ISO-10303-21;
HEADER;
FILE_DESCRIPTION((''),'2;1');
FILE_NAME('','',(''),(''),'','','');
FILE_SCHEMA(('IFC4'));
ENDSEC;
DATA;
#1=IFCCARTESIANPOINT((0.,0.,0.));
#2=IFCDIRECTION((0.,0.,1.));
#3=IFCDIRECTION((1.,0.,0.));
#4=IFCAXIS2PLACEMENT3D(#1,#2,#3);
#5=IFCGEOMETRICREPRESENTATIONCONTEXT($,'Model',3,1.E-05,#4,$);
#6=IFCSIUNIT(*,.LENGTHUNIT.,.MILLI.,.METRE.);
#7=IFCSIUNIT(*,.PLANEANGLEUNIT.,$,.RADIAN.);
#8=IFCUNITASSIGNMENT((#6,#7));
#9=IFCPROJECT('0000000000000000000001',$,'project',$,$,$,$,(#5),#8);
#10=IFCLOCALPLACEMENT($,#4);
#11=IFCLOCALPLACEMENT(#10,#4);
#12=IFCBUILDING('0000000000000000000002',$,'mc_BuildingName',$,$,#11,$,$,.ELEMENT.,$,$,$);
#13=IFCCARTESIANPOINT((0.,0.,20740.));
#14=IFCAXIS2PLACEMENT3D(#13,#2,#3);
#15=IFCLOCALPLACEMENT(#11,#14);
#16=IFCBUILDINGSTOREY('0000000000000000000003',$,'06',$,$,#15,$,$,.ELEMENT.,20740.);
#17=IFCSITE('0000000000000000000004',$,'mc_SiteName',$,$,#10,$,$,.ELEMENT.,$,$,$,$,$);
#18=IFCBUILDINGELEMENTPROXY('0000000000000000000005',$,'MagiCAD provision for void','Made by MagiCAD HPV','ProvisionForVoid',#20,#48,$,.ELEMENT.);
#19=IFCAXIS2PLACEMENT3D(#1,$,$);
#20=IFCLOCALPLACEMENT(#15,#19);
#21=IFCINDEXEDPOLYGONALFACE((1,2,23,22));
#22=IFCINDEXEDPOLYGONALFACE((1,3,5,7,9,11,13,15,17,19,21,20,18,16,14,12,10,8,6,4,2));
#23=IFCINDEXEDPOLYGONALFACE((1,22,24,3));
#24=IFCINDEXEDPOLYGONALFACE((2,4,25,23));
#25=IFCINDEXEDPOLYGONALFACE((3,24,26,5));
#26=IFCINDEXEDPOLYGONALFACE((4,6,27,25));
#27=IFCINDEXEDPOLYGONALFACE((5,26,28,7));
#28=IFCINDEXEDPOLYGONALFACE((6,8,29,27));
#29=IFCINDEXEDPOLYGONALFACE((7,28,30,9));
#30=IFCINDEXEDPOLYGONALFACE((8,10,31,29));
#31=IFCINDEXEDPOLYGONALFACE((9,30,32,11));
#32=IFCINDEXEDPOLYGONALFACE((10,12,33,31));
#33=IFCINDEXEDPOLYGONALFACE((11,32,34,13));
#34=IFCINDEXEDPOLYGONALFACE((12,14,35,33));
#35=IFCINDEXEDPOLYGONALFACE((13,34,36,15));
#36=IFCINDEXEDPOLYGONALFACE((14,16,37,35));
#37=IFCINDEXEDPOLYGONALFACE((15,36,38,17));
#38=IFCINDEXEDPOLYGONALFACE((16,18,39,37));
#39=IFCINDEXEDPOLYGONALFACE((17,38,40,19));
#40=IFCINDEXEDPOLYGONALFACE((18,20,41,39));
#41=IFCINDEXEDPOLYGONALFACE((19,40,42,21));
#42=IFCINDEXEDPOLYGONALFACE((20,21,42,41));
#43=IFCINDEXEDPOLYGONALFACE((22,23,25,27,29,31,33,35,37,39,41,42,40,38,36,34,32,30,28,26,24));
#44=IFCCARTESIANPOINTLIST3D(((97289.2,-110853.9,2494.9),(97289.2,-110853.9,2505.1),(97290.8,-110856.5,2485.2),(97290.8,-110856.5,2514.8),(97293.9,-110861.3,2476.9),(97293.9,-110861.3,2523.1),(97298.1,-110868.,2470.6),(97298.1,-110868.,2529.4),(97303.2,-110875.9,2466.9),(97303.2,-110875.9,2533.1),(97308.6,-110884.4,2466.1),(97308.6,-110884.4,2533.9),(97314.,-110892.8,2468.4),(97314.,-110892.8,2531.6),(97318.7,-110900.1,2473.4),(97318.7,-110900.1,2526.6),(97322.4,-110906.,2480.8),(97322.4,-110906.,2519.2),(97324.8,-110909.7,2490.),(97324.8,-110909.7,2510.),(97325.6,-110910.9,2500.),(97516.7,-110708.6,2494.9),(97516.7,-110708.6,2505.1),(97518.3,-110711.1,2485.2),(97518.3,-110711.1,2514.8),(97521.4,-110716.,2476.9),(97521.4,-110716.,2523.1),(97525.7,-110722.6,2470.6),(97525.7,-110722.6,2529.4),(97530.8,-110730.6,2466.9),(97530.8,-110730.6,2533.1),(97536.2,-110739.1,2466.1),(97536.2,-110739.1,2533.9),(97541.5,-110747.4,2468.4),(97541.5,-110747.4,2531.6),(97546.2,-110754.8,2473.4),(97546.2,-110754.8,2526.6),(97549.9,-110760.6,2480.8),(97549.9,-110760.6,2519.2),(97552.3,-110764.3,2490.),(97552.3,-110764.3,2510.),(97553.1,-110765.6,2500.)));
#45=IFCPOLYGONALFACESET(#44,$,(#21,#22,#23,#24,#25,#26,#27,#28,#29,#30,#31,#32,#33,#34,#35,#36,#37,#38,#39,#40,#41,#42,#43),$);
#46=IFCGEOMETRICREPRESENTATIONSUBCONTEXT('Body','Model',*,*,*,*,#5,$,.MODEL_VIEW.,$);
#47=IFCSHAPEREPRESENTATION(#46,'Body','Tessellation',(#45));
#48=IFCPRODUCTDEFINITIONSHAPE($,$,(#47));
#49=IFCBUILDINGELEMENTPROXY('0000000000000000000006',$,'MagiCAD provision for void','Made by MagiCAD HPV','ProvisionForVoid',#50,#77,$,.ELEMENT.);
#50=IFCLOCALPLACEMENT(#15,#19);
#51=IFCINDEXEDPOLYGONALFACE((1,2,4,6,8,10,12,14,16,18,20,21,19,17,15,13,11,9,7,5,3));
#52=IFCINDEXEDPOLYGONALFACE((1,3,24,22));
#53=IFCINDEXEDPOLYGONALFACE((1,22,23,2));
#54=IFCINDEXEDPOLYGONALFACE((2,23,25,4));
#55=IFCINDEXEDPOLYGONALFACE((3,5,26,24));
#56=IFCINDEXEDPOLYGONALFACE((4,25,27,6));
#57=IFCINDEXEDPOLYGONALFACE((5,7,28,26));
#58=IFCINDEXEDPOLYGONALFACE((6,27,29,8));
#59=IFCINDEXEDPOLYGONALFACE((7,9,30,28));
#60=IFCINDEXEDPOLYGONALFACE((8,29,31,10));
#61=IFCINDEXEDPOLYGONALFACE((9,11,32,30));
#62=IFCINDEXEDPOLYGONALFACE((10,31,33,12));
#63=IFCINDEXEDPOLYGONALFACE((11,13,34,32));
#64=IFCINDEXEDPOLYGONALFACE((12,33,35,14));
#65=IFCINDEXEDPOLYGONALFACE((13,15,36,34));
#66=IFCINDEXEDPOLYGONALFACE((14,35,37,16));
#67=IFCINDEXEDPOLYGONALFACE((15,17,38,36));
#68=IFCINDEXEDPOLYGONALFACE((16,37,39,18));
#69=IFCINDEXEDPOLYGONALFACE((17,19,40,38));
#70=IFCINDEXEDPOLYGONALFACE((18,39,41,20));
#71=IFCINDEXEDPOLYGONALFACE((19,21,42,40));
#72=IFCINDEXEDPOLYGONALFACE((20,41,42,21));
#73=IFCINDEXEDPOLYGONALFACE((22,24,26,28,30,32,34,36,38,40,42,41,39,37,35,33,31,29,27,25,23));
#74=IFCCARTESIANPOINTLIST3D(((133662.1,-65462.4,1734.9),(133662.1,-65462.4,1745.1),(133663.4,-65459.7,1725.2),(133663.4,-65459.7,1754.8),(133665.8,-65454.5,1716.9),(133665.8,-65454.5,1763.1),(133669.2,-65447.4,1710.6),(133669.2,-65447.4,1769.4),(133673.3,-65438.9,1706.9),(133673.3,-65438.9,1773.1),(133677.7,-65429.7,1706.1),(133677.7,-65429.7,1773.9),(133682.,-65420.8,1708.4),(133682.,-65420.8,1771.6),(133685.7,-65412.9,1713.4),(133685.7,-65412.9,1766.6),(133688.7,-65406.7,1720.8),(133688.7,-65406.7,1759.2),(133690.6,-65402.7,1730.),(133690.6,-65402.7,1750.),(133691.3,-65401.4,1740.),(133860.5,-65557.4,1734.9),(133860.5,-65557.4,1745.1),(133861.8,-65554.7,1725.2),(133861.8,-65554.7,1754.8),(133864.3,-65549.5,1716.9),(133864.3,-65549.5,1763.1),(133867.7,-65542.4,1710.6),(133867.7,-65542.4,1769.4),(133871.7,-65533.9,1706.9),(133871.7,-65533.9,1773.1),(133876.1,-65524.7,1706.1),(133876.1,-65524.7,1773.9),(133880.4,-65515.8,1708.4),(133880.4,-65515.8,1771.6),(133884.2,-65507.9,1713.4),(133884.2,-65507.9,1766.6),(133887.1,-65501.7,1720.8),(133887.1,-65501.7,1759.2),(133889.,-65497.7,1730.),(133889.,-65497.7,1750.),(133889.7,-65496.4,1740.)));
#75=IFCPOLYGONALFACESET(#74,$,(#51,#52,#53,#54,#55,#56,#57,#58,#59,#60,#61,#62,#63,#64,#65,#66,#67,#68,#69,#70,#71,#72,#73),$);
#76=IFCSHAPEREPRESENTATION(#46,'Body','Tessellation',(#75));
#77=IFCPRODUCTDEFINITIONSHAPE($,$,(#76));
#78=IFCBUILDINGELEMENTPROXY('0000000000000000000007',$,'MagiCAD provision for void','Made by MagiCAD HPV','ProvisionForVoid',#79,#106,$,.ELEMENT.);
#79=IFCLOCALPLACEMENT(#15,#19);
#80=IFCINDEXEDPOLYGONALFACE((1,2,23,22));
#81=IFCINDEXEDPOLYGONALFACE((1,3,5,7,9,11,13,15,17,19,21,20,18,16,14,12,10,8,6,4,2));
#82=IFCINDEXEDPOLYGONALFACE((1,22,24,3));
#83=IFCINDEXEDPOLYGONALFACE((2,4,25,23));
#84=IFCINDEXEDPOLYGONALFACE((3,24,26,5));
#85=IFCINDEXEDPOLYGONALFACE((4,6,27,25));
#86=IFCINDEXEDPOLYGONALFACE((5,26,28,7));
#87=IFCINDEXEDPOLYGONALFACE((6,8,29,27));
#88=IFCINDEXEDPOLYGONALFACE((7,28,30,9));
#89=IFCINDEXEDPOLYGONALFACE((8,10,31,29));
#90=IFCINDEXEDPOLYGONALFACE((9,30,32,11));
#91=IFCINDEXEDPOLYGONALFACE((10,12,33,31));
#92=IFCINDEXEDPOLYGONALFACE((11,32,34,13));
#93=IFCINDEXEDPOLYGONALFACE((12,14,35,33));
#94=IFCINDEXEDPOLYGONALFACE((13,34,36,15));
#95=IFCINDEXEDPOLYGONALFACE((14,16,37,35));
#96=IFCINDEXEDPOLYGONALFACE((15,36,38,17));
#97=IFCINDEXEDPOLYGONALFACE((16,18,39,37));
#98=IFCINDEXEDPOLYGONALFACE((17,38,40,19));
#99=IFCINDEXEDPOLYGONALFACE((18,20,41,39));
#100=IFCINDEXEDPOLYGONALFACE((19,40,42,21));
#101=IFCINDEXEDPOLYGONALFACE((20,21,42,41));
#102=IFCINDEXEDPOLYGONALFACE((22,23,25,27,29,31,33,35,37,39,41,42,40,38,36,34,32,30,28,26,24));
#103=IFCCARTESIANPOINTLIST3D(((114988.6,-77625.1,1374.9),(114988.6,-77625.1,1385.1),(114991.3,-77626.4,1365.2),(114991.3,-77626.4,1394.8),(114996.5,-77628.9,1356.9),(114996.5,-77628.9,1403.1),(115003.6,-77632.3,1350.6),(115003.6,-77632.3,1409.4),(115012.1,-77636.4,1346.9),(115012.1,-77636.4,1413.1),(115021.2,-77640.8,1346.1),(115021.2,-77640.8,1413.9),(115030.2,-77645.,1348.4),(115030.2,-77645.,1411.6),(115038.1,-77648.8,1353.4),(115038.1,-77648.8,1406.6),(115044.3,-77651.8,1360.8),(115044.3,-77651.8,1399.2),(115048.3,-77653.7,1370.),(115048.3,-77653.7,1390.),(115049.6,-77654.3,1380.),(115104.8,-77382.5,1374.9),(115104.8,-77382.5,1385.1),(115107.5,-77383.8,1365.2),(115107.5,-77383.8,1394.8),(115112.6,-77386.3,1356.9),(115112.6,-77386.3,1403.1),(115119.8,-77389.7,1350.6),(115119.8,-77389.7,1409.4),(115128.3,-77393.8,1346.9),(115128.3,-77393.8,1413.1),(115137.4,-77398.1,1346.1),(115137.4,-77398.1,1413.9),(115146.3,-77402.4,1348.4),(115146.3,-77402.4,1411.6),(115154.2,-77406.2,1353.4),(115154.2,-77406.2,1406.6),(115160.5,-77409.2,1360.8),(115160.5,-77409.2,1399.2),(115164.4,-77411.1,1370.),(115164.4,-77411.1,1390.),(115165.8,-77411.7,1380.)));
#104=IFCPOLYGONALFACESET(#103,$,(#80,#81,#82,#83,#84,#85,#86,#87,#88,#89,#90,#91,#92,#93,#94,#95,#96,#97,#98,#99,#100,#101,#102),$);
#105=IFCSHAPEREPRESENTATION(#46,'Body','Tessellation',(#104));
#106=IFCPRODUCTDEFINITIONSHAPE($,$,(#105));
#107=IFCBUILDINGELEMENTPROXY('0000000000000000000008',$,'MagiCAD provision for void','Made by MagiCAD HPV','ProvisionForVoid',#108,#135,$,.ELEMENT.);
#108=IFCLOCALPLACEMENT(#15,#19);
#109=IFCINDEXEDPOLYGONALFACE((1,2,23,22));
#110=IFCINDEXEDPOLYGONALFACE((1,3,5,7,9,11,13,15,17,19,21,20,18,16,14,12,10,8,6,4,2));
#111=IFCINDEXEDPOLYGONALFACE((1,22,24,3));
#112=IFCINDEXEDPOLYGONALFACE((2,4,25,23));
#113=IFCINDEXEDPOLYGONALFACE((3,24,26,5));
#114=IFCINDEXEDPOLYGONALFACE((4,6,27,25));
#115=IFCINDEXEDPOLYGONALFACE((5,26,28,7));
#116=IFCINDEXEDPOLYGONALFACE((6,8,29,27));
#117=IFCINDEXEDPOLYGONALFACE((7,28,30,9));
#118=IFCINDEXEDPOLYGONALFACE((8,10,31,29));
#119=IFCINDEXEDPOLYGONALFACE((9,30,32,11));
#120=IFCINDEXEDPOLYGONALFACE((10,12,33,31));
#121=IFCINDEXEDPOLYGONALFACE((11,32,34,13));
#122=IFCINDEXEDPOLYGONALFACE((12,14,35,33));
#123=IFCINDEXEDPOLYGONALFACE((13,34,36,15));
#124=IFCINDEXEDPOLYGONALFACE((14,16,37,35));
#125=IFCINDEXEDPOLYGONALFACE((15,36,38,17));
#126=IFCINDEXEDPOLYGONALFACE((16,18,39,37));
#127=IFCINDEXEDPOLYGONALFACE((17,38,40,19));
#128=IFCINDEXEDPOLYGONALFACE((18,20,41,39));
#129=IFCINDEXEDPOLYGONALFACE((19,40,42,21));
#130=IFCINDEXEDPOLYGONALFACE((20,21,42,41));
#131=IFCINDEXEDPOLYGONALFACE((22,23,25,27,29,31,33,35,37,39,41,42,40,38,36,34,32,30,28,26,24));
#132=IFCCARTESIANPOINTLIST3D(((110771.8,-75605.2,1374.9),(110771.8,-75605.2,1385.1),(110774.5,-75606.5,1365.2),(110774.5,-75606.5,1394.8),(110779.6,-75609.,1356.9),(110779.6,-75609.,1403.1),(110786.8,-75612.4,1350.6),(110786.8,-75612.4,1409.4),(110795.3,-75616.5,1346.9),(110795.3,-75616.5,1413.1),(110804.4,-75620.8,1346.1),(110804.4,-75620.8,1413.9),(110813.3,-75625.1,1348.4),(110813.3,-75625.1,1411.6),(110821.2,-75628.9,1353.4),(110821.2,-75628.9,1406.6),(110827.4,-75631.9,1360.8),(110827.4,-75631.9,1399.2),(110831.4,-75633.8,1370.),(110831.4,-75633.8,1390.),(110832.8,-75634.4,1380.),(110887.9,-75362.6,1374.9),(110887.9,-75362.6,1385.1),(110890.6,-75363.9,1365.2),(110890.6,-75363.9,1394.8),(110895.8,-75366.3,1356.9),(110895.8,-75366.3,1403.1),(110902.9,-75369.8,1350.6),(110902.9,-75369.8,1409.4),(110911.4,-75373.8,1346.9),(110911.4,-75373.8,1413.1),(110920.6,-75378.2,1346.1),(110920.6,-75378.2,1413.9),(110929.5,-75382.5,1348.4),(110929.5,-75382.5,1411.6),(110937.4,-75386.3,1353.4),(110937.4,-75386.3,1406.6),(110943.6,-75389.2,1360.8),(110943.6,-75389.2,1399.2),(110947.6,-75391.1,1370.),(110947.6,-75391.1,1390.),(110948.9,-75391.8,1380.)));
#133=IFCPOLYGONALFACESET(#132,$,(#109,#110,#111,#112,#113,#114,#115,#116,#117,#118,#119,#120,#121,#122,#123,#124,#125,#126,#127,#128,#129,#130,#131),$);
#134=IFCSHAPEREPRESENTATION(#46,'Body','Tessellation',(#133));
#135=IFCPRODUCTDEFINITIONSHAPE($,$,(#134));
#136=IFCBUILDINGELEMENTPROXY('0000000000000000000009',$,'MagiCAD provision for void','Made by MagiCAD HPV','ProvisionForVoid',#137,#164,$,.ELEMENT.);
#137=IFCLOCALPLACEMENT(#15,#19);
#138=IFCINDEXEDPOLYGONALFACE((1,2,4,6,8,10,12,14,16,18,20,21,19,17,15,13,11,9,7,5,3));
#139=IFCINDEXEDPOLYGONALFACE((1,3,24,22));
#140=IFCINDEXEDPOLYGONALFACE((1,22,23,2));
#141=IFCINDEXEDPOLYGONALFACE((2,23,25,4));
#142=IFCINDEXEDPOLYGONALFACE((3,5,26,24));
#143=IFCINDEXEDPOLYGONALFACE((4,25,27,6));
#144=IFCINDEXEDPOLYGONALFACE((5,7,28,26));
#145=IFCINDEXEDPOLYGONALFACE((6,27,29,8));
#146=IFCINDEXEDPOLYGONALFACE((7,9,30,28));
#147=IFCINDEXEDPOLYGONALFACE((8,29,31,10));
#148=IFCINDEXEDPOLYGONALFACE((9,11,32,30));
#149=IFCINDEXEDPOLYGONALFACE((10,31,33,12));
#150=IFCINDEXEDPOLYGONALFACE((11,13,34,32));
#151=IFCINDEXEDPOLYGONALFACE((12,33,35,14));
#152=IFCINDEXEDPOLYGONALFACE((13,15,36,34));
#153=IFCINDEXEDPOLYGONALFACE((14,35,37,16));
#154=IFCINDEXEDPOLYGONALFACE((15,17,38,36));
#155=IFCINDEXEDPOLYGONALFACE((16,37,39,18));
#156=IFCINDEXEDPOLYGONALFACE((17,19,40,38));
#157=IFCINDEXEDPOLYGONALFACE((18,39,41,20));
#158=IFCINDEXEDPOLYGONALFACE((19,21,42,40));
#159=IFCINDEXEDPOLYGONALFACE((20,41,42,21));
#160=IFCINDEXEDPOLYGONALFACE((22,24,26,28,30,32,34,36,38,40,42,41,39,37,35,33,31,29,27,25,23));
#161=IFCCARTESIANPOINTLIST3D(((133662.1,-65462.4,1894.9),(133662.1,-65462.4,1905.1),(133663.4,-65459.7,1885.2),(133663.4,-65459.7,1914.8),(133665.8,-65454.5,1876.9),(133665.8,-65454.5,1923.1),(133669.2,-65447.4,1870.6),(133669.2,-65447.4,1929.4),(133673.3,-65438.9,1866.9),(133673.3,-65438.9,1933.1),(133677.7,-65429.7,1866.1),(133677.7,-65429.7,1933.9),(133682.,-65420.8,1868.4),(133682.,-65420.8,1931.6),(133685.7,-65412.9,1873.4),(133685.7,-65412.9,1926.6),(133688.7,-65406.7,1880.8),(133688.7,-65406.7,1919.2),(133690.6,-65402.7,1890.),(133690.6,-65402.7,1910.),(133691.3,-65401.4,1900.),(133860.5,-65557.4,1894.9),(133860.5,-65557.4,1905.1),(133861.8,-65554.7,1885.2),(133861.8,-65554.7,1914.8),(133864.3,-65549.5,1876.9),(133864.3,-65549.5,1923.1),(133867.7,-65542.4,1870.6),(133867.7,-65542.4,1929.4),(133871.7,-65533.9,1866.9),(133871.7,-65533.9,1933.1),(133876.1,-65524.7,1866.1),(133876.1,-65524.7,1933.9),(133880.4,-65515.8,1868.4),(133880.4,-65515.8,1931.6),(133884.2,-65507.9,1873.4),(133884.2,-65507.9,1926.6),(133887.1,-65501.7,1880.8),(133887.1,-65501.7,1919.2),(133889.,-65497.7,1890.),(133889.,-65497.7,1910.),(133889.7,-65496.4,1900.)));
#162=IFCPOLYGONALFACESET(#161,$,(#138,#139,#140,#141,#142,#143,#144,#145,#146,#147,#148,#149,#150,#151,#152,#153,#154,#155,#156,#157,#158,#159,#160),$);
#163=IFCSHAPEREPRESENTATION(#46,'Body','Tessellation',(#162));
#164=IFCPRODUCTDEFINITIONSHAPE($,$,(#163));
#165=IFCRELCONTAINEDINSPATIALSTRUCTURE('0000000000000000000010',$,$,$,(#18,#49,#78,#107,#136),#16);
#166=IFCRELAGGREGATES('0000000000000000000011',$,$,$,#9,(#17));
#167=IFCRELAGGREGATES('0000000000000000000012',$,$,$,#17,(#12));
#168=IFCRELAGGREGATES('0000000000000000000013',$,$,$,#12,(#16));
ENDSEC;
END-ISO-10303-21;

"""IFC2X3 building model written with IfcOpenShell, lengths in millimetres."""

from ifc_helpers import new_model, si_unit, frame, origin_with_axes, origin_2d_with_axis, place, context, subcontext, project, spatial, circle, extrude, source, transform, mapped, element, save


model = new_model("IFC2X3")

# Units and contexts
model_context = context("Model", 3, precision=1e-05, world=origin_with_axes())
body_context = subcontext(model_context, "Body", "Model", "MODEL_VIEW")
ifc_project = project(units=[si_unit("LENGTHUNIT", "METRE", prefix="MILLI"), si_unit("PLANEANGLEUNIT", "RADIAN")], contexts=[model_context])

# Site, building, storey
site_placement = place(None, origin_with_axes())
site = spatial("IfcSite", under=ifc_project, at=site_placement, Name="mc_SiteName", CompositionType="ELEMENT")
building_placement = place(site_placement, origin_with_axes())
building = spatial("IfcBuilding", under=site, at=building_placement, Name="mc_BuildingName", CompositionType="ELEMENT")
storey_placement = place(building_placement, frame((0.0, 0.0, 20740.0), z_axis=(0.0, 0.0, 1.0), x_axis=(1.0, 0.0, 0.0)))
storey = spatial("IfcBuildingStorey", under=building, at=storey_placement, Name="06", CompositionType="ELEMENT", Elevation=20740.0)

# Building element proxies
shared_shape_1 = source(origin_with_axes(), body_context, "Body", "SweptSolid", [
    extrude(circle(Radius=34.0, at=origin_2d_with_axis()), frame((0.0, 0.0, 0.0), z_axis=(1.0, 0.0, 0.0), x_axis=(0.0, 1.0, 0.0)), (0.0, 0.0, 1.0), 270.0),
])
proxy_1_placement = place(storey_placement, frame((97534.8, -110737.0, 2500.0), z_axis=(0.0, 0.0, 1.0), x_axis=(-0.842809, -0.538213, 0.0)))
element("IfcBuildingElementProxy", 1, at=proxy_1_placement, inside=storey, Name="MagiCAD provision for void", Description="Made by MagiCAD HPV", ObjectType="ProvisionForVoid", CompositionType="ELEMENT", context=body_context, shape_type="MappedRepresentation", body=[
    mapped(shared_shape_1, transform((0.0, 0.0, 0.0), scale=1.0)),
])
shared_shape_2 = source(origin_with_axes(), body_context, "Body", "SweptSolid", [
    extrude(circle(Radius=34.0, at=origin_2d_with_axis()), frame((0.0, 0.0, 0.0), z_axis=(1.0, 0.0, 0.0), x_axis=(0.0, 1.0, 0.0)), (0.0, 0.0, 1.0), 220.0),
])
proxy_2_placement = place(storey_placement, frame((133676.6, -65432.0, 1740.0), z_axis=(0.0, 0.0, 1.0), x_axis=(0.901941, -0.431859, 0.0)))
element("IfcBuildingElementProxy", 2, at=proxy_2_placement, inside=storey, Name="MagiCAD provision for void", Description="Made by MagiCAD HPV", ObjectType="ProvisionForVoid", CompositionType="ELEMENT", context=body_context, shape_type="MappedRepresentation", body=[
    mapped(shared_shape_2, transform((0.0, 0.0, 0.0), scale=1.0)),
])
shared_shape_3 = source(origin_with_axes(), body_context, "Body", "SweptSolid", [
    extrude(circle(Radius=34.0, at=origin_2d_with_axis()), frame((0.0, 0.0, 0.0), z_axis=(1.0, 0.0, 0.0), x_axis=(0.0, 1.0, 0.0)), (0.0, 0.0, 1.0), 269.0),
])
proxy_3_placement = place(storey_placement, frame((115135.1, -77397.0, 1380.0), z_axis=(0.0, 0.0, 1.0), x_axis=(-0.431882, -0.90193, 0.0)))
element("IfcBuildingElementProxy", 3, at=proxy_3_placement, inside=storey, Name="MagiCAD provision for void", Description="Made by MagiCAD HPV", ObjectType="ProvisionForVoid", CompositionType="ELEMENT", context=body_context, shape_type="MappedRepresentation", body=[
    mapped(shared_shape_3, transform((0.0, 0.0, 0.0), scale=1.0)),
])
shared_shape_4 = source(origin_with_axes(), body_context, "Body", "SweptSolid", [
    extrude(circle(Radius=34.0, at=origin_2d_with_axis()), frame((0.0, 0.0, 0.0), z_axis=(1.0, 0.0, 0.0), x_axis=(0.0, 1.0, 0.0)), (0.0, 0.0, 1.0), 269.0),
])
proxy_4_placement = place(storey_placement, frame((110918.3, -75377.1, 1380.0), z_axis=(0.0, 0.0, 1.0), x_axis=(-0.431882, -0.90193, 0.0)))
element("IfcBuildingElementProxy", 4, at=proxy_4_placement, inside=storey, Name="MagiCAD provision for void", Description="Made by MagiCAD HPV", ObjectType="ProvisionForVoid", CompositionType="ELEMENT", context=body_context, shape_type="MappedRepresentation", body=[
    mapped(shared_shape_4, transform((0.0, 0.0, 0.0), scale=1.0)),
])
shared_shape_5 = source(origin_with_axes(), body_context, "Body", "SweptSolid", [
    extrude(circle(Radius=34.0, at=origin_2d_with_axis()), frame((0.0, 0.0, 0.0), z_axis=(1.0, 0.0, 0.0), x_axis=(0.0, 1.0, 0.0)), (0.0, 0.0, 1.0), 220.0),
])
proxy_5_placement = place(storey_placement, frame((133676.6, -65432.0, 1900.0), z_axis=(0.0, 0.0, 1.0), x_axis=(0.901941, -0.431859, 0.0)))
element("IfcBuildingElementProxy", 5, at=proxy_5_placement, inside=storey, Name="MagiCAD provision for void", Description="Made by MagiCAD HPV", ObjectType="ProvisionForVoid", CompositionType="ELEMENT", context=body_context, shape_type="MappedRepresentation", body=[
    mapped(shared_shape_5, transform((0.0, 0.0, 0.0), scale=1.0)),
])

save(model, "model.ifc")
